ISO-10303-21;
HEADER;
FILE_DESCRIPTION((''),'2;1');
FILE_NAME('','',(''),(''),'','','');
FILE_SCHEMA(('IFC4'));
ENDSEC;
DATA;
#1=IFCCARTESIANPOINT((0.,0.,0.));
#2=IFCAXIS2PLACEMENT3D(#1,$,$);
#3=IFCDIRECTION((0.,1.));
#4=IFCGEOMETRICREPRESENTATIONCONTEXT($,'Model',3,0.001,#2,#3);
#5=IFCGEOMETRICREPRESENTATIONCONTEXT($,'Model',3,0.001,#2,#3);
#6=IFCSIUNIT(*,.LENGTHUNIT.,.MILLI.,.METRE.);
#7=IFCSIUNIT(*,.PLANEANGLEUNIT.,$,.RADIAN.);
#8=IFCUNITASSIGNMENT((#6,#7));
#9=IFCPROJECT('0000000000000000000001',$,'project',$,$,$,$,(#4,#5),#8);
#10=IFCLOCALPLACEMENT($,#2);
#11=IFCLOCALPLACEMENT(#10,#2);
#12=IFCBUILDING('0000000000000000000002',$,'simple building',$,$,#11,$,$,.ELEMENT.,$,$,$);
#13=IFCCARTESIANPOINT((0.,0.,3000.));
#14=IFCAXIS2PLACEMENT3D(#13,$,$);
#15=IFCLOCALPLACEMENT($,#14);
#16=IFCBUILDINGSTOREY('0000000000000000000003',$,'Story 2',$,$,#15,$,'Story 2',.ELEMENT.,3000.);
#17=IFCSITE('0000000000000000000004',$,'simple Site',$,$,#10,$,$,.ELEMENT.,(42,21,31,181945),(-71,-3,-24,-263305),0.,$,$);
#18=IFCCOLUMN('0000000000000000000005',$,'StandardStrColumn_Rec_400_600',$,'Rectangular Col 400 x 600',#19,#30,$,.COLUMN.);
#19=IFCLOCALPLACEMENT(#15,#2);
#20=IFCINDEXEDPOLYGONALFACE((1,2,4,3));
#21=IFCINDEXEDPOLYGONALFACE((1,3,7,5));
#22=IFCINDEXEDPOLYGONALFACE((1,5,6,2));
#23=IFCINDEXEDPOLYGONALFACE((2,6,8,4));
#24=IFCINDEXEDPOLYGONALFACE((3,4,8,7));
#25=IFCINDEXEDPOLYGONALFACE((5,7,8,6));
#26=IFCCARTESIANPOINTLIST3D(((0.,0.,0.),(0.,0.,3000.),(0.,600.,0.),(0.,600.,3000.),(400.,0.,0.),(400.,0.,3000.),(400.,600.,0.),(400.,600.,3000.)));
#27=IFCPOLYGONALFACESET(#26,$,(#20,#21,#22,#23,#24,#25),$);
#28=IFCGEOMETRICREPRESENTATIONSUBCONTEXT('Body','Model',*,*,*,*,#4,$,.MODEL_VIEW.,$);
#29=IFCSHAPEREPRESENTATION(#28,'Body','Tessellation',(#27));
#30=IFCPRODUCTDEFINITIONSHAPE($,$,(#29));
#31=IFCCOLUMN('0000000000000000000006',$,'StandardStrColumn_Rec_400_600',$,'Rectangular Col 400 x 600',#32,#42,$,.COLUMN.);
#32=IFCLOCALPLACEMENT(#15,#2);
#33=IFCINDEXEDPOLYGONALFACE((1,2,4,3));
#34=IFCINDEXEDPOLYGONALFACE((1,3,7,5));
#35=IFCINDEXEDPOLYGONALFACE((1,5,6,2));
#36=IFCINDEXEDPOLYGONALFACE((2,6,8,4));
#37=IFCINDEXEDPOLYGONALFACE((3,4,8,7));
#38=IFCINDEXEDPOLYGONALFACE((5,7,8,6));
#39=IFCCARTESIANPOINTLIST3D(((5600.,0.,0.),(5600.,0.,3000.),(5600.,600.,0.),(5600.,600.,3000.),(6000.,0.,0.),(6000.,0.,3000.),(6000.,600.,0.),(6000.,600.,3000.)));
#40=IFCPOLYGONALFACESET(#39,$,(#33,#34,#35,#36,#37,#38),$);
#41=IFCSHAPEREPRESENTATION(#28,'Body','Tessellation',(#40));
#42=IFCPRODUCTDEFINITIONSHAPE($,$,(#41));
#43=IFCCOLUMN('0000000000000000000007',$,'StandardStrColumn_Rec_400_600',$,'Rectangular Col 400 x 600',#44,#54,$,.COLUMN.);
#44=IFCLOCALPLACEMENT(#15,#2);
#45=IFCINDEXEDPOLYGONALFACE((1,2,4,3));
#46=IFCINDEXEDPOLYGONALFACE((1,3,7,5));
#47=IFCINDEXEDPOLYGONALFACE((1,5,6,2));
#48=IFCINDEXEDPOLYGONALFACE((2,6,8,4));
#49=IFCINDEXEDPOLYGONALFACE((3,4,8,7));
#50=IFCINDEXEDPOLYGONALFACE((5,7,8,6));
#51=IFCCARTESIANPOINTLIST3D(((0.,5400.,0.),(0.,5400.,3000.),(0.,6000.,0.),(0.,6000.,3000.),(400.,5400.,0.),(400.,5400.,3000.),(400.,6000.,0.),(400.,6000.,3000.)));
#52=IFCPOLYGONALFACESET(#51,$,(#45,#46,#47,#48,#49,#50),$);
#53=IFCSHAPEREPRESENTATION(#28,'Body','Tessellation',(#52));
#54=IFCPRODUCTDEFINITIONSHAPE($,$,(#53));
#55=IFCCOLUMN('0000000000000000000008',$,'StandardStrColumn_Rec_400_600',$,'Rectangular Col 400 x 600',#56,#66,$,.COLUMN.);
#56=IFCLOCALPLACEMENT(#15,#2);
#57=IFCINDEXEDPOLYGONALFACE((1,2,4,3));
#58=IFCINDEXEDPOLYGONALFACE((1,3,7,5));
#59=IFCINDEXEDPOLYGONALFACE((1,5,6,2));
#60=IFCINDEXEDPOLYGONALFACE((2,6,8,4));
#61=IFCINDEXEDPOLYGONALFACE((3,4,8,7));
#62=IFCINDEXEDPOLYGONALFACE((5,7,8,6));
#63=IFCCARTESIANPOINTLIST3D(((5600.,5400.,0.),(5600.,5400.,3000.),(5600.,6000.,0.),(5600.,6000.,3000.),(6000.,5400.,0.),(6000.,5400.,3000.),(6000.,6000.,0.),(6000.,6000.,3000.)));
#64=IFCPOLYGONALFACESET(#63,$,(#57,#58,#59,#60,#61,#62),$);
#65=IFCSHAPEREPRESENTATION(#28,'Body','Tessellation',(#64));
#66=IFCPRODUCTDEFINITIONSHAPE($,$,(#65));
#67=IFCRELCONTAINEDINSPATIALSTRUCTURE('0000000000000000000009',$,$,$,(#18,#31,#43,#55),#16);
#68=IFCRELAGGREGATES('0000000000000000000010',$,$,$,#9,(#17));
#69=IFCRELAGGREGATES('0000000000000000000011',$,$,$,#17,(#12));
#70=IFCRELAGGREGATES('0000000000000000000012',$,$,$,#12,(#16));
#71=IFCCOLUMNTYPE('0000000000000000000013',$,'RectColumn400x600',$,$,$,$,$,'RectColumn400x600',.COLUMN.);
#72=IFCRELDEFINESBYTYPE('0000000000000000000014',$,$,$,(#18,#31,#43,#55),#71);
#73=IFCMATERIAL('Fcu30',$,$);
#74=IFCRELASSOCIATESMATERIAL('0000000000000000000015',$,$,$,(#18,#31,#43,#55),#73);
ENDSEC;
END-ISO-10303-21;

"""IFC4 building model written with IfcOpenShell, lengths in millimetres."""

from ifc_helpers import new_model, si_unit, direction, frame, origin, origin_with_axes, origin_2d_with_axis, place, context, subcontext, project, spatial, rectangle, extrude, material, material_profile, profile_set, profile_usage, type_object, element, save


model = new_model("IFC4")

# Units and contexts
model_context_1 = context("Model", 3, precision=0.001, world=origin(), true_north=direction((0.0, 1.0)))
model_context_2 = context("Model", 3, precision=0.001, world=origin(), true_north=direction((0.0, 1.0)))
body_context = subcontext(model_context_1, "Body", "Model", "MODEL_VIEW")
ifc_project = project(units=[si_unit("LENGTHUNIT", "METRE", prefix="MILLI"), si_unit("PLANEANGLEUNIT", "RADIAN")], contexts=[model_context_1, model_context_2])

# Site, building, storey
site_placement = place(None, origin())
site = spatial("IfcSite", under=ifc_project, at=site_placement, Name="simple Site", CompositionType="ELEMENT", RefLatitude=(42, 21, 31, 181945), RefLongitude=(-71, -3, -24, -263305), RefElevation=0.0)
building_placement = place(site_placement, origin())
building = spatial("IfcBuilding", under=site, at=building_placement, Name="simple building", CompositionType="ELEMENT")
storey_placement = place(None, frame((0.0, 0.0, 3000.0)))
storey = spatial("IfcBuildingStorey", under=building, at=storey_placement, Name="Story 2", LongName="Story 2", CompositionType="ELEMENT", Elevation=3000.0)

# Columns
ifc_material = material(Name="Fcu30")
ifc_material_profile = material_profile(ifc_material, rectangle(XDim=400.0, YDim=600.0, at=origin_2d_with_axis()))
ifc_profile_set = profile_set([ifc_material_profile])
ifc_profile_usage_1 = profile_usage(ifc_profile_set, cardinal=7)
column_type = type_object("IfcColumnType", Name="RectColumn400x600", ElementType="RectColumn400x600", PredefinedType="COLUMN")
column_1_placement = place(None, frame((200.0, 300.0, 3000.0), z_axis=(0.0, 0.0, 1.0), x_axis=(1.0, 0.0, 0.0)))
element("IfcColumn", 1, at=column_1_placement, inside=storey, type_object=column_type, material=ifc_profile_usage_1, Name="StandardStrColumn_Rec_400_600", ObjectType="Rectangular Col 400 x 600", PredefinedType="COLUMN", context=body_context, shape_type="SweptSolid", body=[
    extrude(rectangle(XDim=400.0, YDim=600.0, at=origin_2d_with_axis()), origin_with_axes(), (0.0, 0.0, 1.0), 3000.0),
])
ifc_profile_usage_2 = profile_usage(ifc_profile_set, cardinal=9)
column_2_placement = place(None, frame((5800.0, 300.0, 3000.0), z_axis=(0.0, 0.0, 1.0), x_axis=(1.0, 0.0, 0.0)))
element("IfcColumn", 2, at=column_2_placement, inside=storey, type_object=column_type, material=ifc_profile_usage_2, Name="StandardStrColumn_Rec_400_600", ObjectType="Rectangular Col 400 x 600", PredefinedType="COLUMN", context=body_context, shape_type="SweptSolid", body=[
    extrude(rectangle(XDim=400.0, YDim=600.0, at=origin_2d_with_axis()), origin_with_axes(), (0.0, 0.0, 1.0), 3000.0),
])
ifc_profile_usage_3 = profile_usage(ifc_profile_set, cardinal=1)
column_3_placement = place(None, frame((200.0, 5700.0, 3000.0), z_axis=(0.0, 0.0, 1.0), x_axis=(1.0, 0.0, 0.0)))
element("IfcColumn", 3, at=column_3_placement, inside=storey, type_object=column_type, material=ifc_profile_usage_3, Name="StandardStrColumn_Rec_400_600", ObjectType="Rectangular Col 400 x 600", PredefinedType="COLUMN", context=body_context, shape_type="SweptSolid", body=[
    extrude(rectangle(XDim=400.0, YDim=600.0, at=origin_2d_with_axis()), origin_with_axes(), (0.0, 0.0, 1.0), 3000.0),
])
ifc_profile_usage_4 = profile_usage(ifc_profile_set, cardinal=3)
column_4_placement = place(None, frame((5800.0, 5700.0, 3000.0), z_axis=(0.0, 0.0, 1.0), x_axis=(1.0, 0.0, 0.0)))
element("IfcColumn", 4, at=column_4_placement, inside=storey, type_object=column_type, material=ifc_profile_usage_4, Name="StandardStrColumn_Rec_400_600", ObjectType="Rectangular Col 400 x 600", PredefinedType="COLUMN", context=body_context, shape_type="SweptSolid", body=[
    extrude(rectangle(XDim=400.0, YDim=600.0, at=origin_2d_with_axis()), origin_with_axes(), (0.0, 0.0, 1.0), 3000.0),
])

save(model, "model.ifc")
